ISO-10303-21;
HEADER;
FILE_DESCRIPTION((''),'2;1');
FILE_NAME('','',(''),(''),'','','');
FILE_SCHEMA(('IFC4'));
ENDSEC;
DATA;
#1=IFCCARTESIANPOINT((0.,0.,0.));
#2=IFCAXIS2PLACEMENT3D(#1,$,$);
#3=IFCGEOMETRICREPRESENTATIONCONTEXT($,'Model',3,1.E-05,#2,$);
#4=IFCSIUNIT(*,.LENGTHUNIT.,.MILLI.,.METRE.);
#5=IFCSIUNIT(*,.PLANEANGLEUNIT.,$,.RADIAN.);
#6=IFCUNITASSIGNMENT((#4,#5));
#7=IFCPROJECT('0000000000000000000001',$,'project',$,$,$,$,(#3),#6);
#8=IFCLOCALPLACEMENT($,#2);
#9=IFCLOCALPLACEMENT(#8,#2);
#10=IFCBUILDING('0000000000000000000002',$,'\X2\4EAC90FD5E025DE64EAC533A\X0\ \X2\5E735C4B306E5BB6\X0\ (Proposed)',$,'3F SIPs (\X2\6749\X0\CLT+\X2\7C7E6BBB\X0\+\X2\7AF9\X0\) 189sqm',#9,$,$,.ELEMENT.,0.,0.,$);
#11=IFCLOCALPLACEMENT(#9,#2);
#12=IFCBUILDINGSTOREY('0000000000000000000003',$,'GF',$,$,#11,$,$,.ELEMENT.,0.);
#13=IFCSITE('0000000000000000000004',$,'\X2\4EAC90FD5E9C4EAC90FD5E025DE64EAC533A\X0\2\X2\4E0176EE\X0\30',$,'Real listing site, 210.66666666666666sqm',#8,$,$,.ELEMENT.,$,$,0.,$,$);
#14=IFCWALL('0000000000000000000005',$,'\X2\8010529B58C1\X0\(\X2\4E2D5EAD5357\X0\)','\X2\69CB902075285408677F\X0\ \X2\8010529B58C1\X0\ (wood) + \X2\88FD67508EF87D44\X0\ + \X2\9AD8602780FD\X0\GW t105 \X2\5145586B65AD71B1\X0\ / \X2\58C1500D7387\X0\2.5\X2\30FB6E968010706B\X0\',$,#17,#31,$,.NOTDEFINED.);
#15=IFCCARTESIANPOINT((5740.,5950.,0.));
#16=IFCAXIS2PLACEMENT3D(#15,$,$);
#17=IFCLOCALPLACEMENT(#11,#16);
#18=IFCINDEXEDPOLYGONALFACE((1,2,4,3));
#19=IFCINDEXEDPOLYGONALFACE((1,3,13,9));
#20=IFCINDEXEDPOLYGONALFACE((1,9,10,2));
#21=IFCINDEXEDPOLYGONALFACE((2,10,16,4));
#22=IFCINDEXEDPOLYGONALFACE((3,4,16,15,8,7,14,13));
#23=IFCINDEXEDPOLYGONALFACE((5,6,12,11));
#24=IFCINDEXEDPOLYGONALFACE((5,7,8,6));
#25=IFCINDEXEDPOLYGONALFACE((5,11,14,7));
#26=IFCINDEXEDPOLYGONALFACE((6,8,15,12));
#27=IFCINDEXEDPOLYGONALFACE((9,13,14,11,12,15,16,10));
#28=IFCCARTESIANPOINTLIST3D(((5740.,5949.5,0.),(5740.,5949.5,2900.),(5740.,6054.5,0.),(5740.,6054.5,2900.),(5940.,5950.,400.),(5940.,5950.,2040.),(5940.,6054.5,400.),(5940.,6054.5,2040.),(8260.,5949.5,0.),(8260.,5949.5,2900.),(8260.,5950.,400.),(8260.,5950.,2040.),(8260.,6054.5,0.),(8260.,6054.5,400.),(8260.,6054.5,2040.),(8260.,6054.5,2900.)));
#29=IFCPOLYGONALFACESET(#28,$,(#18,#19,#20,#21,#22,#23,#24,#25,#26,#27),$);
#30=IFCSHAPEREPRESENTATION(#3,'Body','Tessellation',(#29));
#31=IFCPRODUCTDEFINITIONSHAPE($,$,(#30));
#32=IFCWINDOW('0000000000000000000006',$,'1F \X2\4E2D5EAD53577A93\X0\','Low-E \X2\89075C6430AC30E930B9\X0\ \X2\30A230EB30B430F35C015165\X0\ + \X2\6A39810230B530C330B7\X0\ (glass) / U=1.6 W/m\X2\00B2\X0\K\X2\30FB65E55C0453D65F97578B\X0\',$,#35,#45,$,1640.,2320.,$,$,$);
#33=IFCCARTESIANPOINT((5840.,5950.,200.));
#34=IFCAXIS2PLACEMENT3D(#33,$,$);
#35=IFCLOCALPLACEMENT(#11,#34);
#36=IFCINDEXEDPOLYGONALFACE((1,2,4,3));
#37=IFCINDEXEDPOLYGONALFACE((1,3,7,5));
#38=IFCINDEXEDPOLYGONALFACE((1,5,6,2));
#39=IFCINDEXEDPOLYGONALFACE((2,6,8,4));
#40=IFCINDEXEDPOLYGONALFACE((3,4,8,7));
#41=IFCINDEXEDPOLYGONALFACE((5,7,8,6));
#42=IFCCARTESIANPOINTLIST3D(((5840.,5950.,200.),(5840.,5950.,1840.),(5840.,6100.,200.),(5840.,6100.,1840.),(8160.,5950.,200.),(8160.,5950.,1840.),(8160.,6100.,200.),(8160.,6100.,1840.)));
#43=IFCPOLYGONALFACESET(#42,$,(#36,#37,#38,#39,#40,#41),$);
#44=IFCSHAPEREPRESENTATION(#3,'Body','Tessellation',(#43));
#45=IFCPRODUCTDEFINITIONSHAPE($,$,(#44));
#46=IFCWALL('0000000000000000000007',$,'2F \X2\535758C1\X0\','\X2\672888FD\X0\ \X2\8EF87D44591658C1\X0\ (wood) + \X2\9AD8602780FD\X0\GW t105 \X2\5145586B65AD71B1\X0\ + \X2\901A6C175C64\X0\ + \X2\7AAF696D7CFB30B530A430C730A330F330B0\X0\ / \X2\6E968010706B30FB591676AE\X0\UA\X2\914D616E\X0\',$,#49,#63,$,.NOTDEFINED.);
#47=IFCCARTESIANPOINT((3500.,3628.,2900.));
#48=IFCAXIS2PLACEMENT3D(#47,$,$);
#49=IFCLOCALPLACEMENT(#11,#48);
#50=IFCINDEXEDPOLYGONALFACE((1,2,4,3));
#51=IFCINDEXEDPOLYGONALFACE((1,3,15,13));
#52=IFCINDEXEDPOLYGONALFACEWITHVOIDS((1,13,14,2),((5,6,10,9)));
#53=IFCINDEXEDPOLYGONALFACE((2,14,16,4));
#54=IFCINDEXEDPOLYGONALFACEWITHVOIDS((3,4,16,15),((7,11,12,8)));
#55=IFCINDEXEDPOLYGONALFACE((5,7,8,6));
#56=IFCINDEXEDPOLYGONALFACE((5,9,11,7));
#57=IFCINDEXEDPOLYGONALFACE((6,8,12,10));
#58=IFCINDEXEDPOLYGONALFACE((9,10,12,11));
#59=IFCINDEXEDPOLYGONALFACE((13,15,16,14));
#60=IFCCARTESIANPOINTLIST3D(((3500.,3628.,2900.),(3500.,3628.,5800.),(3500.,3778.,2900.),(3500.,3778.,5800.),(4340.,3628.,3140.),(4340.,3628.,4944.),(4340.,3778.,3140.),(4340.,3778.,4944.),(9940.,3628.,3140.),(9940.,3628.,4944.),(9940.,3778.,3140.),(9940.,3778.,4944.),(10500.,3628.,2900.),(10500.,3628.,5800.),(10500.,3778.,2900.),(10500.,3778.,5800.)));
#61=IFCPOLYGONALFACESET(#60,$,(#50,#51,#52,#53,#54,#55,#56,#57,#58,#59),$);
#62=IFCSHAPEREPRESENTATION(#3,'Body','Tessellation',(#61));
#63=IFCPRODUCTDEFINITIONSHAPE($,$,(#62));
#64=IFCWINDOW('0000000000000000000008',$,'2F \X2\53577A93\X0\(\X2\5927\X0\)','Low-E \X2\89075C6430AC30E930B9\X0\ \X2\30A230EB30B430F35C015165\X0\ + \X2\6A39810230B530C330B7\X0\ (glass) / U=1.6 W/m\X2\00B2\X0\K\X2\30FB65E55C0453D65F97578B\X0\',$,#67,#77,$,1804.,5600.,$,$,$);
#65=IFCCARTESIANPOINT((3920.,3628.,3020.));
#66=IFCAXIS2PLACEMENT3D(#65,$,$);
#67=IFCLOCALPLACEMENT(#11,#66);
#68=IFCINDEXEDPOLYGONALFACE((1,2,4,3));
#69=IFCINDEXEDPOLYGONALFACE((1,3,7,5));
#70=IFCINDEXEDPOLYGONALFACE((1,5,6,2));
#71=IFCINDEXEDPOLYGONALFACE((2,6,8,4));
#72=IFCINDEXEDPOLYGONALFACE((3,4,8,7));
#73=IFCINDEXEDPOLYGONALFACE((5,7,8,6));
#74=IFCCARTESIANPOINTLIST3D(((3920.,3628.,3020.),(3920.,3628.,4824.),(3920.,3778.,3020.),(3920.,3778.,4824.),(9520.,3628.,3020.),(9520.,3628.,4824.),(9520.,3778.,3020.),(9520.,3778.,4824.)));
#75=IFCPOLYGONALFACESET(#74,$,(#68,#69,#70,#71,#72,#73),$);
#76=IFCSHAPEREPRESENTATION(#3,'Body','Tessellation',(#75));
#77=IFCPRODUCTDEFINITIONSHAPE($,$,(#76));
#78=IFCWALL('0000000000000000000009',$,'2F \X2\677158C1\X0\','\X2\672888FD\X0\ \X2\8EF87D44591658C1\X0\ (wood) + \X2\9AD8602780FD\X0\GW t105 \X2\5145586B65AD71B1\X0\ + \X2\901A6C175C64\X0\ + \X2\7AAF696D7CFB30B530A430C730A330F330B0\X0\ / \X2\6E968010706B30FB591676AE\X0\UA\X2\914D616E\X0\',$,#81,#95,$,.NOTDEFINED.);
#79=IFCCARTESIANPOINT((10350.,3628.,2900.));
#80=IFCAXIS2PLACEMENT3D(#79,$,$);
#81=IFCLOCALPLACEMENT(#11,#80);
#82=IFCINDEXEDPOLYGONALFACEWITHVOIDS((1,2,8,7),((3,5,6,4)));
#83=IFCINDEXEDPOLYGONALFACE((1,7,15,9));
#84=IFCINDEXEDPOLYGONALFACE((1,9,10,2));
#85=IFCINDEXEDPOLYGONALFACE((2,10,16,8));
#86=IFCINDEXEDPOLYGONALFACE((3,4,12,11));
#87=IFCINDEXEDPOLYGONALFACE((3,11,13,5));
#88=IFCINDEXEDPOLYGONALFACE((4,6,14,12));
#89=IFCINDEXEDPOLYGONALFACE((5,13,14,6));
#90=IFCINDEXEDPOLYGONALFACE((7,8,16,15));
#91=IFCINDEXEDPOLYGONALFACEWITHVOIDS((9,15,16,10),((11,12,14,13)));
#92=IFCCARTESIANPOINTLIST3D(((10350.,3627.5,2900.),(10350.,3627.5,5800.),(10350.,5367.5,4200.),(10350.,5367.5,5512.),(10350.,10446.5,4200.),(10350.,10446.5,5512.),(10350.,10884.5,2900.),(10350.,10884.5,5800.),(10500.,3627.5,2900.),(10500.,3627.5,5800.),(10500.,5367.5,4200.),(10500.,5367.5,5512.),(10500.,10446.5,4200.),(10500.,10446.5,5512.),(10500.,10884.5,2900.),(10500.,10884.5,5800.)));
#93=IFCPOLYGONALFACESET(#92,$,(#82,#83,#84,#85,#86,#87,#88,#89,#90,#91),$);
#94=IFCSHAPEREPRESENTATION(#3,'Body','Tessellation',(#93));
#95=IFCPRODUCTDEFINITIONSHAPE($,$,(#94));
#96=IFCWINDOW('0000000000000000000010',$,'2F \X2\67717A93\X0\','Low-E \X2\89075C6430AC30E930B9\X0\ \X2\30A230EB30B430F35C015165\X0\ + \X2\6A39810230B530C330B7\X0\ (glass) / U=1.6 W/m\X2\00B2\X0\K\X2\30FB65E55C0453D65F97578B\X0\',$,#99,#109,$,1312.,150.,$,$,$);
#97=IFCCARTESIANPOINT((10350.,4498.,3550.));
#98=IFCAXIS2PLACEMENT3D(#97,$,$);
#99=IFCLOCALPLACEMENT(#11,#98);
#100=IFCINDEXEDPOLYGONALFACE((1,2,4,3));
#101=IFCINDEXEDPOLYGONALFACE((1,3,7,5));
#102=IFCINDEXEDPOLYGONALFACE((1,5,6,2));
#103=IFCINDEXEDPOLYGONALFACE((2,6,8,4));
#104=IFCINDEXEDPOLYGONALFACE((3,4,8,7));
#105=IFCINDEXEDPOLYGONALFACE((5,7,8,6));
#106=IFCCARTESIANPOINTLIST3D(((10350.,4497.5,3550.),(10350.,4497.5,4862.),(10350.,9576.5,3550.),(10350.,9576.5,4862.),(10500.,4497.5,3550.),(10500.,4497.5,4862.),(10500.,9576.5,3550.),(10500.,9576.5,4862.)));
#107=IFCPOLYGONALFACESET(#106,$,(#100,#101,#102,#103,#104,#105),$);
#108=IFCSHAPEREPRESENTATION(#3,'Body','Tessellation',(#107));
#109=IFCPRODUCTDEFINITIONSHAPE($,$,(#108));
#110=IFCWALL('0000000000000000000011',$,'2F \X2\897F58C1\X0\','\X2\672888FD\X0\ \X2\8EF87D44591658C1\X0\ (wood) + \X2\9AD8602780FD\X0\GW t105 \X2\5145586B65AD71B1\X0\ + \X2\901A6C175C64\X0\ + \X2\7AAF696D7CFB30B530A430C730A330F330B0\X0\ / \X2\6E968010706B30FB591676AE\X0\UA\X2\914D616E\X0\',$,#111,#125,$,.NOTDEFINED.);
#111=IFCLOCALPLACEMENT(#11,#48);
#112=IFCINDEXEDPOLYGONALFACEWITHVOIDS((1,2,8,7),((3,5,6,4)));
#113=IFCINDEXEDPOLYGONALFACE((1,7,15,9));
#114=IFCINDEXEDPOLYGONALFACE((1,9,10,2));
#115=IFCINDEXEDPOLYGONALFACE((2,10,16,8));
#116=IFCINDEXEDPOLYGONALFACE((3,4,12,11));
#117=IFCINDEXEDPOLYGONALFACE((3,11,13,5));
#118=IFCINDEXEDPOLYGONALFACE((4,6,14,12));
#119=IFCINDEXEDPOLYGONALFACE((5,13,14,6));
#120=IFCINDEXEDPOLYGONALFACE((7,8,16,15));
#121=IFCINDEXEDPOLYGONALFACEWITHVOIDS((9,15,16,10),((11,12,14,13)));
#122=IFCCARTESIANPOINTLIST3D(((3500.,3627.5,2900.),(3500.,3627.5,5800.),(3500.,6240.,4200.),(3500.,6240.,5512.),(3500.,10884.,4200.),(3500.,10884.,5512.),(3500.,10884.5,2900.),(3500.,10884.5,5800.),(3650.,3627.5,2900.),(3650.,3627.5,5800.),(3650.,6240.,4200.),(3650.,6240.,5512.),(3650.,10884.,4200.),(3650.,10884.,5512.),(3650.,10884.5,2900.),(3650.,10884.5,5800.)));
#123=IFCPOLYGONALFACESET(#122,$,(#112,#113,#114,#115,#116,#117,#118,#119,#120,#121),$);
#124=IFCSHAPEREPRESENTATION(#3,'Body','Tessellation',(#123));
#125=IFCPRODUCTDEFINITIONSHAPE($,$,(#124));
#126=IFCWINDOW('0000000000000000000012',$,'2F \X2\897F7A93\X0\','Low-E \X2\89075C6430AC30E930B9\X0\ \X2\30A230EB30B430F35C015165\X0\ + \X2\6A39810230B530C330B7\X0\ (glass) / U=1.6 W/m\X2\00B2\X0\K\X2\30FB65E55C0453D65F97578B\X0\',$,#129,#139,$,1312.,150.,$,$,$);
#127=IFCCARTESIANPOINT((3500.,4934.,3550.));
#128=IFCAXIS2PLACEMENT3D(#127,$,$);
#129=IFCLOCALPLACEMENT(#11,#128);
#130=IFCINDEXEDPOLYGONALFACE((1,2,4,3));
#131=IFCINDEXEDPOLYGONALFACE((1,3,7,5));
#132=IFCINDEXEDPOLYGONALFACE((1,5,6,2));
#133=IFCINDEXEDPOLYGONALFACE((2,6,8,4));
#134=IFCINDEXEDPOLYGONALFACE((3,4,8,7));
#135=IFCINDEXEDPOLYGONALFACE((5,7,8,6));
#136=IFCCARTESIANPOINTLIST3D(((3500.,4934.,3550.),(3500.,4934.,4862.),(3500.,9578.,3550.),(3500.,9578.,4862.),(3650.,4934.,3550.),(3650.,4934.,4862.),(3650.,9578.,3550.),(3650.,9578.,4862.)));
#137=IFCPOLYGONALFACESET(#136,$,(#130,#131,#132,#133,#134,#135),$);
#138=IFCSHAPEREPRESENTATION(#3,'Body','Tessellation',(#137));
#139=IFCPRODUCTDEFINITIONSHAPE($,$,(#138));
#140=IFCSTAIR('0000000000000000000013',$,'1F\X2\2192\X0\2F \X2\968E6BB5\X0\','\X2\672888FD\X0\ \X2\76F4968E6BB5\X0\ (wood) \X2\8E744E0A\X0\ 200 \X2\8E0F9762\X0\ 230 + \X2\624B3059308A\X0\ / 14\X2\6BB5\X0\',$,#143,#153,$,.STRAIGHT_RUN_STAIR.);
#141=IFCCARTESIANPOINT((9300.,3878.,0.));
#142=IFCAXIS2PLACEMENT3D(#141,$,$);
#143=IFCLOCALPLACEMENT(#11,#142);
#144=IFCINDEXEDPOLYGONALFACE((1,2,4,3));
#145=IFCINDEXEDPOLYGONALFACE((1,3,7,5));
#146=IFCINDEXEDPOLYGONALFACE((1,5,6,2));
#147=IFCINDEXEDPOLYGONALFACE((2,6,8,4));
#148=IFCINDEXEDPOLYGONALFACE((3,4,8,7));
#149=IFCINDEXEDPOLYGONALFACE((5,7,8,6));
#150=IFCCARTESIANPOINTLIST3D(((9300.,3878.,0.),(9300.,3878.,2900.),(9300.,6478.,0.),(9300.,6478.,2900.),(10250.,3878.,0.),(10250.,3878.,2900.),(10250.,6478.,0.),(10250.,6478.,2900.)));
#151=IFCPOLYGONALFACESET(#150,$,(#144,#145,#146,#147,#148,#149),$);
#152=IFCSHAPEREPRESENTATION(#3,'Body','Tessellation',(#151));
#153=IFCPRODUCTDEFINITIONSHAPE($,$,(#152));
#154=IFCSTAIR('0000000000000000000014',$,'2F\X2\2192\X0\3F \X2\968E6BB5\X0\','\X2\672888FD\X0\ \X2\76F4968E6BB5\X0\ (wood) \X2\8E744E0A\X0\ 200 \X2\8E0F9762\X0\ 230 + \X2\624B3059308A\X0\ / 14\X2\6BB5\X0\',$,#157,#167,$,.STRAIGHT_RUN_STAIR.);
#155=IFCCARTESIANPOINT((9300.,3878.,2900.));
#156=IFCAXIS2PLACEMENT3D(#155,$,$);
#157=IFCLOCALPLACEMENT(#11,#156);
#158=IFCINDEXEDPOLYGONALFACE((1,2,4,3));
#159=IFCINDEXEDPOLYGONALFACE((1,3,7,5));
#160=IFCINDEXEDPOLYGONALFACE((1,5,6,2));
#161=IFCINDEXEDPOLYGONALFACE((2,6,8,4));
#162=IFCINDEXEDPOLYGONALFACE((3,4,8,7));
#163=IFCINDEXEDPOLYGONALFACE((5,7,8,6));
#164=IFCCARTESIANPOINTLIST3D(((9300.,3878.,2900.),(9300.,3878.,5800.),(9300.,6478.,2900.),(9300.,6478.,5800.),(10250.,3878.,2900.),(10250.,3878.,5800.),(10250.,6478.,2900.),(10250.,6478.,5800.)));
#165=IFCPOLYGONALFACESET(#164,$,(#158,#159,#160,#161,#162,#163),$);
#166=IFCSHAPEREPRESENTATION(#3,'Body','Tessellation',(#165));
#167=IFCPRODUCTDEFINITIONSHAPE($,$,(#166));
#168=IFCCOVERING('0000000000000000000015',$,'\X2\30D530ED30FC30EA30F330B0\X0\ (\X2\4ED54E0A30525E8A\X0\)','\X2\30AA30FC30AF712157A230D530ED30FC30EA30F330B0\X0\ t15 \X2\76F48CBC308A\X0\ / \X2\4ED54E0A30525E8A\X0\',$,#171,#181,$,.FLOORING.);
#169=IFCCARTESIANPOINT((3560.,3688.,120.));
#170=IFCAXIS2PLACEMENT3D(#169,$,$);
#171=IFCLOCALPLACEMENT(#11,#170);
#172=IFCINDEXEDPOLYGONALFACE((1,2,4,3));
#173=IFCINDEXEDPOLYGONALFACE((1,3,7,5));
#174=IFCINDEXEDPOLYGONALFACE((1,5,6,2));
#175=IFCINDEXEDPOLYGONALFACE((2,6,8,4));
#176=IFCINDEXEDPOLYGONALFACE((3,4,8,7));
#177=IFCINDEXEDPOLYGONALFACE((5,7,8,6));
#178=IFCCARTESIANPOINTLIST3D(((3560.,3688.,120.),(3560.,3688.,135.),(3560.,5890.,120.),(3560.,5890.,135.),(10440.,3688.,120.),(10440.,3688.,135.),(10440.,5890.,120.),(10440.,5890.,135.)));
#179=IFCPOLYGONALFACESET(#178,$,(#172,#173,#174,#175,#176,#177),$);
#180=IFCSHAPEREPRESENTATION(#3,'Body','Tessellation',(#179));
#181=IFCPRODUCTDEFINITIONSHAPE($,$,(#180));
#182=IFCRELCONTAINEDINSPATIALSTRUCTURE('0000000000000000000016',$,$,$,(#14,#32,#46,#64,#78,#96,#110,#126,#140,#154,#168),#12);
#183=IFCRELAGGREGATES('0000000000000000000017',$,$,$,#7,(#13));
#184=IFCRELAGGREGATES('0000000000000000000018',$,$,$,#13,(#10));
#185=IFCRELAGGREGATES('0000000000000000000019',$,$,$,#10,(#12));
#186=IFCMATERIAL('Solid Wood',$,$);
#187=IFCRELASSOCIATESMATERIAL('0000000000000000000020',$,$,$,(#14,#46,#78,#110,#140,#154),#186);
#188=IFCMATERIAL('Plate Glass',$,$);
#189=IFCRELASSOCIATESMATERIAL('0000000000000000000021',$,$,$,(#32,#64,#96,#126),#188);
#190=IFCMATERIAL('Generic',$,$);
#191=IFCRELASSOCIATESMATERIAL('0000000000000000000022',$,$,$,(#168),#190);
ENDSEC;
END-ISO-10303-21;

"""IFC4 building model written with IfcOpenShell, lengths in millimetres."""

from ifc_helpers import new_model, si_unit, frame, frame_2d, origin, place, context, project, spatial, rectangle, extrude, material, element, fill, save


model = new_model("IFC4")

# Units and contexts
model_context = context("Model", 3, precision=1e-05, world=origin())
ifc_project = project(units=[si_unit("LENGTHUNIT", "METRE", prefix="MILLI"), si_unit("PLANEANGLEUNIT", "RADIAN")], contexts=[model_context])

# Site, building, storey
site_placement = place(None, origin())
site = spatial("IfcSite", under=ifc_project, at=site_placement, Name="京都府京都市左京区2丁目30", ObjectType="Real listing site, 210.66666666666666sqm", CompositionType="ELEMENT", RefElevation=0.0)
building_placement = place(site_placement, origin())
building = spatial("IfcBuilding", under=site, at=building_placement, Name="京都市左京区 平屋の家 (Proposed)", ObjectType="3F SIPs (杉CLT+籾殻+竹) 189sqm", CompositionType="ELEMENT", ElevationOfRefHeight=0.0, ElevationOfTerrain=0.0)
storey_placement = place(building_placement, origin())
storey = spatial("IfcBuildingStorey", under=building, at=storey_placement, Name="GF", CompositionType="ELEMENT", Elevation=0.0)

# Shared definitions
ifc_material_1 = material(Name="Solid Wood")

# Shared definitions
ifc_material_2 = material(Name="Plate Glass")

# Walls, openings, windows
wall_1_placement = place(storey_placement, frame((5740.0, 5950.0, 0.0)))
wall_1 = element("IfcWall", 1, at=wall_1_placement, inside=storey, material=ifc_material_1, Name="耐力壁(中庭南)", Description="構造用合板 耐力壁 (wood) + 製材軸組 + 高性能GW t105 充填断熱 / 壁倍率2.5・準耐火", PredefinedType="NOTDEFINED", context=model_context, shape_type="SweptSolid", body=[
    extrude(rectangle(XDim=2520.0, YDim=105.0, at=frame_2d((1260.0, 52.0))), frame((5740.0, 5950.0, 0.0)), (0.0, 0.0, 1.0), 2900.0),
])
opening_1_placement = place(storey_placement, frame((5840.0, 5950.0, 200.0)))
opening_1 = element("IfcOpeningElement", 2, at=opening_1_placement, cuts=wall_1, PredefinedType="NOTDEFINED", context=model_context, shape_type="SweptSolid", body=[
    extrude(rectangle(XDim=2320.0, YDim=150.0, at=frame_2d((1160.0, 75.0))), frame((5840.0, 5950.0, 200.0)), (0.0, 0.0, 1.0), 1640.0),
])
window_1_placement = place(storey_placement, frame((5840.0, 5950.0, 200.0)))
window_1 = element("IfcWindow", 3, at=window_1_placement, inside=storey, material=ifc_material_2, Name="1F 中庭南窓", Description="Low-E 複層ガラス アルゴン封入 + 樹脂サッシ (glass) / U=1.6 W/m²K・日射取得型", OverallHeight=1640.0, OverallWidth=2320.0, context=model_context, shape_type="SweptSolid", body=[
    extrude(rectangle(XDim=2320.0, YDim=150.0, at=frame_2d((1160.0, 75.0))), frame((5840.0, 5950.0, 200.0)), (0.0, 0.0, 1.0), 1640.0),
])
fill(opening_1, window_1)
wall_2_placement = place(storey_placement, frame((3500.0, 3628.0, 2900.0)))
wall_2 = element("IfcWall", 4, at=wall_2_placement, inside=storey, material=ifc_material_1, Name="2F 南壁", Description="木製 軸組外壁 (wood) + 高性能GW t105 充填断熱 + 通気層 + 窯業系サイディング / 準耐火・外皮UA配慮", PredefinedType="NOTDEFINED", context=model_context, shape_type="SweptSolid", body=[
    extrude(rectangle(XDim=7000.0, YDim=150.0, at=frame_2d((3500.0, 75.0))), frame((3500.0, 3628.0, 2900.0)), (0.0, 0.0, 1.0), 2900.0),
])
opening_2_placement = place(storey_placement, frame((3920.0, 3628.0, 3020.0)))
opening_2 = element("IfcOpeningElement", 5, at=opening_2_placement, cuts=wall_2, PredefinedType="NOTDEFINED", context=model_context, shape_type="SweptSolid", body=[
    extrude(rectangle(XDim=5600.0, YDim=150.0, at=frame_2d((2800.0, 75.0))), frame((3920.0, 3628.0, 3020.0)), (0.0, 0.0, 1.0), 1804.0),
])
window_2_placement = place(storey_placement, frame((3920.0, 3628.0, 3020.0)))
window_2 = element("IfcWindow", 6, at=window_2_placement, inside=storey, material=ifc_material_2, Name="2F 南窓(大)", Description="Low-E 複層ガラス アルゴン封入 + 樹脂サッシ (glass) / U=1.6 W/m²K・日射取得型", OverallHeight=1804.0, OverallWidth=5600.0, context=model_context, shape_type="SweptSolid", body=[
    extrude(rectangle(XDim=5600.0, YDim=150.0, at=frame_2d((2800.0, 75.0))), frame((3920.0, 3628.0, 3020.0)), (0.0, 0.0, 1.0), 1804.0),
])
fill(opening_2, window_2)
wall_3_placement = place(storey_placement, frame((10350.0, 3628.0, 2900.0)))
wall_3 = element("IfcWall", 7, at=wall_3_placement, inside=storey, material=ifc_material_1, Name="2F 東壁", Description="木製 軸組外壁 (wood) + 高性能GW t105 充填断熱 + 通気層 + 窯業系サイディング / 準耐火・外皮UA配慮", PredefinedType="NOTDEFINED", context=model_context, shape_type="SweptSolid", body=[
    extrude(rectangle(XDim=150.0, YDim=7257.0, at=frame_2d((75.0, 3628.0))), frame((10350.0, 3628.0, 2900.0)), (0.0, 0.0, 1.0), 2900.0),
])
opening_3_placement = place(storey_placement, frame((10350.0, 4498.0, 3550.0)))
opening_3 = element("IfcOpeningElement", 8, at=opening_3_placement, cuts=wall_3, PredefinedType="NOTDEFINED", context=model_context, shape_type="SweptSolid", body=[
    extrude(rectangle(XDim=150.0, YDim=5079.0, at=frame_2d((75.0, 2539.0))), frame((10350.0, 4498.0, 3550.0)), (0.0, 0.0, 1.0), 1312.0),
])
window_3_placement = place(storey_placement, frame((10350.0, 4498.0, 3550.0)))
window_3 = element("IfcWindow", 9, at=window_3_placement, inside=storey, material=ifc_material_2, Name="2F 東窓", Description="Low-E 複層ガラス アルゴン封入 + 樹脂サッシ (glass) / U=1.6 W/m²K・日射取得型", OverallHeight=1312.0, OverallWidth=150.0, context=model_context, shape_type="SweptSolid", body=[
    extrude(rectangle(XDim=150.0, YDim=5079.0, at=frame_2d((75.0, 2539.0))), frame((10350.0, 4498.0, 3550.0)), (0.0, 0.0, 1.0), 1312.0),
])
fill(opening_3, window_3)
wall_4_placement = place(storey_placement, frame((3500.0, 3628.0, 2900.0)))
wall_4 = element("IfcWall", 10, at=wall_4_placement, inside=storey, material=ifc_material_1, Name="2F 西壁", Description="木製 軸組外壁 (wood) + 高性能GW t105 充填断熱 + 通気層 + 窯業系サイディング / 準耐火・外皮UA配慮", PredefinedType="NOTDEFINED", context=model_context, shape_type="SweptSolid", body=[
    extrude(rectangle(XDim=150.0, YDim=7257.0, at=frame_2d((75.0, 3628.0))), frame((3500.0, 3628.0, 2900.0)), (0.0, 0.0, 1.0), 2900.0),
])
opening_4_placement = place(storey_placement, frame((3500.0, 4934.0, 3550.0)))
opening_4 = element("IfcOpeningElement", 11, at=opening_4_placement, cuts=wall_4, PredefinedType="NOTDEFINED", context=model_context, shape_type="SweptSolid", body=[
    extrude(rectangle(XDim=150.0, YDim=4644.0, at=frame_2d((75.0, 2322.0))), frame((3500.0, 4934.0, 3550.0)), (0.0, 0.0, 1.0), 1312.0),
])
window_4_placement = place(storey_placement, frame((3500.0, 4934.0, 3550.0)))
window_4 = element("IfcWindow", 12, at=window_4_placement, inside=storey, material=ifc_material_2, Name="2F 西窓", Description="Low-E 複層ガラス アルゴン封入 + 樹脂サッシ (glass) / U=1.6 W/m²K・日射取得型", OverallHeight=1312.0, OverallWidth=150.0, context=model_context, shape_type="SweptSolid", body=[
    extrude(rectangle(XDim=150.0, YDim=4644.0, at=frame_2d((75.0, 2322.0))), frame((3500.0, 4934.0, 3550.0)), (0.0, 0.0, 1.0), 1312.0),
])
fill(opening_4, window_4)

# Stairs
stair_1_placement = place(storey_placement, frame((9300.0, 3878.0, 0.0)))
element("IfcStair", 13, at=stair_1_placement, inside=storey, material=ifc_material_1, Name="1F→2F 階段", Description="木製 直階段 (wood) 蹴上 200 踏面 230 + 手すり / 14段", PredefinedType="STRAIGHT_RUN_STAIR", context=model_context, shape_type="SweptSolid", body=[
    extrude(rectangle(XDim=950.0, YDim=2600.0, at=frame_2d((475.0, 1300.0))), frame((9300.0, 3878.0, 0.0)), (0.0, 0.0, 1.0), 2900.0),
])
stair_2_placement = place(storey_placement, frame((9300.0, 3878.0, 2900.0)))
element("IfcStair", 14, at=stair_2_placement, inside=storey, material=ifc_material_1, Name="2F→3F 階段", Description="木製 直階段 (wood) 蹴上 200 踏面 230 + 手すり / 14段", PredefinedType="STRAIGHT_RUN_STAIR", context=model_context, shape_type="SweptSolid", body=[
    extrude(rectangle(XDim=950.0, YDim=2600.0, at=frame_2d((475.0, 1300.0))), frame((9300.0, 3878.0, 2900.0)), (0.0, 0.0, 1.0), 2900.0),
])

# Covering
ifc_material_3 = material(Name="Generic")
covering_placement = place(storey_placement, frame((3560.0, 3688.0, 120.0)))
element("IfcCovering", 15, at=covering_placement, inside=storey, material=ifc_material_3, Name="フローリング (仕上げ床)", Description="オーク無垢フローリング t15 直貼り / 仕上げ床", PredefinedType="FLOORING", context=model_context, shape_type="SweptSolid", body=[
    extrude(rectangle(XDim=6880.0, YDim=2202.0, at=frame_2d((3440.0, 1101.0))), frame((3560.0, 3688.0, 120.0)), (0.0, 0.0, 1.0), 15.0),
])

save(model, "model.ifc")
